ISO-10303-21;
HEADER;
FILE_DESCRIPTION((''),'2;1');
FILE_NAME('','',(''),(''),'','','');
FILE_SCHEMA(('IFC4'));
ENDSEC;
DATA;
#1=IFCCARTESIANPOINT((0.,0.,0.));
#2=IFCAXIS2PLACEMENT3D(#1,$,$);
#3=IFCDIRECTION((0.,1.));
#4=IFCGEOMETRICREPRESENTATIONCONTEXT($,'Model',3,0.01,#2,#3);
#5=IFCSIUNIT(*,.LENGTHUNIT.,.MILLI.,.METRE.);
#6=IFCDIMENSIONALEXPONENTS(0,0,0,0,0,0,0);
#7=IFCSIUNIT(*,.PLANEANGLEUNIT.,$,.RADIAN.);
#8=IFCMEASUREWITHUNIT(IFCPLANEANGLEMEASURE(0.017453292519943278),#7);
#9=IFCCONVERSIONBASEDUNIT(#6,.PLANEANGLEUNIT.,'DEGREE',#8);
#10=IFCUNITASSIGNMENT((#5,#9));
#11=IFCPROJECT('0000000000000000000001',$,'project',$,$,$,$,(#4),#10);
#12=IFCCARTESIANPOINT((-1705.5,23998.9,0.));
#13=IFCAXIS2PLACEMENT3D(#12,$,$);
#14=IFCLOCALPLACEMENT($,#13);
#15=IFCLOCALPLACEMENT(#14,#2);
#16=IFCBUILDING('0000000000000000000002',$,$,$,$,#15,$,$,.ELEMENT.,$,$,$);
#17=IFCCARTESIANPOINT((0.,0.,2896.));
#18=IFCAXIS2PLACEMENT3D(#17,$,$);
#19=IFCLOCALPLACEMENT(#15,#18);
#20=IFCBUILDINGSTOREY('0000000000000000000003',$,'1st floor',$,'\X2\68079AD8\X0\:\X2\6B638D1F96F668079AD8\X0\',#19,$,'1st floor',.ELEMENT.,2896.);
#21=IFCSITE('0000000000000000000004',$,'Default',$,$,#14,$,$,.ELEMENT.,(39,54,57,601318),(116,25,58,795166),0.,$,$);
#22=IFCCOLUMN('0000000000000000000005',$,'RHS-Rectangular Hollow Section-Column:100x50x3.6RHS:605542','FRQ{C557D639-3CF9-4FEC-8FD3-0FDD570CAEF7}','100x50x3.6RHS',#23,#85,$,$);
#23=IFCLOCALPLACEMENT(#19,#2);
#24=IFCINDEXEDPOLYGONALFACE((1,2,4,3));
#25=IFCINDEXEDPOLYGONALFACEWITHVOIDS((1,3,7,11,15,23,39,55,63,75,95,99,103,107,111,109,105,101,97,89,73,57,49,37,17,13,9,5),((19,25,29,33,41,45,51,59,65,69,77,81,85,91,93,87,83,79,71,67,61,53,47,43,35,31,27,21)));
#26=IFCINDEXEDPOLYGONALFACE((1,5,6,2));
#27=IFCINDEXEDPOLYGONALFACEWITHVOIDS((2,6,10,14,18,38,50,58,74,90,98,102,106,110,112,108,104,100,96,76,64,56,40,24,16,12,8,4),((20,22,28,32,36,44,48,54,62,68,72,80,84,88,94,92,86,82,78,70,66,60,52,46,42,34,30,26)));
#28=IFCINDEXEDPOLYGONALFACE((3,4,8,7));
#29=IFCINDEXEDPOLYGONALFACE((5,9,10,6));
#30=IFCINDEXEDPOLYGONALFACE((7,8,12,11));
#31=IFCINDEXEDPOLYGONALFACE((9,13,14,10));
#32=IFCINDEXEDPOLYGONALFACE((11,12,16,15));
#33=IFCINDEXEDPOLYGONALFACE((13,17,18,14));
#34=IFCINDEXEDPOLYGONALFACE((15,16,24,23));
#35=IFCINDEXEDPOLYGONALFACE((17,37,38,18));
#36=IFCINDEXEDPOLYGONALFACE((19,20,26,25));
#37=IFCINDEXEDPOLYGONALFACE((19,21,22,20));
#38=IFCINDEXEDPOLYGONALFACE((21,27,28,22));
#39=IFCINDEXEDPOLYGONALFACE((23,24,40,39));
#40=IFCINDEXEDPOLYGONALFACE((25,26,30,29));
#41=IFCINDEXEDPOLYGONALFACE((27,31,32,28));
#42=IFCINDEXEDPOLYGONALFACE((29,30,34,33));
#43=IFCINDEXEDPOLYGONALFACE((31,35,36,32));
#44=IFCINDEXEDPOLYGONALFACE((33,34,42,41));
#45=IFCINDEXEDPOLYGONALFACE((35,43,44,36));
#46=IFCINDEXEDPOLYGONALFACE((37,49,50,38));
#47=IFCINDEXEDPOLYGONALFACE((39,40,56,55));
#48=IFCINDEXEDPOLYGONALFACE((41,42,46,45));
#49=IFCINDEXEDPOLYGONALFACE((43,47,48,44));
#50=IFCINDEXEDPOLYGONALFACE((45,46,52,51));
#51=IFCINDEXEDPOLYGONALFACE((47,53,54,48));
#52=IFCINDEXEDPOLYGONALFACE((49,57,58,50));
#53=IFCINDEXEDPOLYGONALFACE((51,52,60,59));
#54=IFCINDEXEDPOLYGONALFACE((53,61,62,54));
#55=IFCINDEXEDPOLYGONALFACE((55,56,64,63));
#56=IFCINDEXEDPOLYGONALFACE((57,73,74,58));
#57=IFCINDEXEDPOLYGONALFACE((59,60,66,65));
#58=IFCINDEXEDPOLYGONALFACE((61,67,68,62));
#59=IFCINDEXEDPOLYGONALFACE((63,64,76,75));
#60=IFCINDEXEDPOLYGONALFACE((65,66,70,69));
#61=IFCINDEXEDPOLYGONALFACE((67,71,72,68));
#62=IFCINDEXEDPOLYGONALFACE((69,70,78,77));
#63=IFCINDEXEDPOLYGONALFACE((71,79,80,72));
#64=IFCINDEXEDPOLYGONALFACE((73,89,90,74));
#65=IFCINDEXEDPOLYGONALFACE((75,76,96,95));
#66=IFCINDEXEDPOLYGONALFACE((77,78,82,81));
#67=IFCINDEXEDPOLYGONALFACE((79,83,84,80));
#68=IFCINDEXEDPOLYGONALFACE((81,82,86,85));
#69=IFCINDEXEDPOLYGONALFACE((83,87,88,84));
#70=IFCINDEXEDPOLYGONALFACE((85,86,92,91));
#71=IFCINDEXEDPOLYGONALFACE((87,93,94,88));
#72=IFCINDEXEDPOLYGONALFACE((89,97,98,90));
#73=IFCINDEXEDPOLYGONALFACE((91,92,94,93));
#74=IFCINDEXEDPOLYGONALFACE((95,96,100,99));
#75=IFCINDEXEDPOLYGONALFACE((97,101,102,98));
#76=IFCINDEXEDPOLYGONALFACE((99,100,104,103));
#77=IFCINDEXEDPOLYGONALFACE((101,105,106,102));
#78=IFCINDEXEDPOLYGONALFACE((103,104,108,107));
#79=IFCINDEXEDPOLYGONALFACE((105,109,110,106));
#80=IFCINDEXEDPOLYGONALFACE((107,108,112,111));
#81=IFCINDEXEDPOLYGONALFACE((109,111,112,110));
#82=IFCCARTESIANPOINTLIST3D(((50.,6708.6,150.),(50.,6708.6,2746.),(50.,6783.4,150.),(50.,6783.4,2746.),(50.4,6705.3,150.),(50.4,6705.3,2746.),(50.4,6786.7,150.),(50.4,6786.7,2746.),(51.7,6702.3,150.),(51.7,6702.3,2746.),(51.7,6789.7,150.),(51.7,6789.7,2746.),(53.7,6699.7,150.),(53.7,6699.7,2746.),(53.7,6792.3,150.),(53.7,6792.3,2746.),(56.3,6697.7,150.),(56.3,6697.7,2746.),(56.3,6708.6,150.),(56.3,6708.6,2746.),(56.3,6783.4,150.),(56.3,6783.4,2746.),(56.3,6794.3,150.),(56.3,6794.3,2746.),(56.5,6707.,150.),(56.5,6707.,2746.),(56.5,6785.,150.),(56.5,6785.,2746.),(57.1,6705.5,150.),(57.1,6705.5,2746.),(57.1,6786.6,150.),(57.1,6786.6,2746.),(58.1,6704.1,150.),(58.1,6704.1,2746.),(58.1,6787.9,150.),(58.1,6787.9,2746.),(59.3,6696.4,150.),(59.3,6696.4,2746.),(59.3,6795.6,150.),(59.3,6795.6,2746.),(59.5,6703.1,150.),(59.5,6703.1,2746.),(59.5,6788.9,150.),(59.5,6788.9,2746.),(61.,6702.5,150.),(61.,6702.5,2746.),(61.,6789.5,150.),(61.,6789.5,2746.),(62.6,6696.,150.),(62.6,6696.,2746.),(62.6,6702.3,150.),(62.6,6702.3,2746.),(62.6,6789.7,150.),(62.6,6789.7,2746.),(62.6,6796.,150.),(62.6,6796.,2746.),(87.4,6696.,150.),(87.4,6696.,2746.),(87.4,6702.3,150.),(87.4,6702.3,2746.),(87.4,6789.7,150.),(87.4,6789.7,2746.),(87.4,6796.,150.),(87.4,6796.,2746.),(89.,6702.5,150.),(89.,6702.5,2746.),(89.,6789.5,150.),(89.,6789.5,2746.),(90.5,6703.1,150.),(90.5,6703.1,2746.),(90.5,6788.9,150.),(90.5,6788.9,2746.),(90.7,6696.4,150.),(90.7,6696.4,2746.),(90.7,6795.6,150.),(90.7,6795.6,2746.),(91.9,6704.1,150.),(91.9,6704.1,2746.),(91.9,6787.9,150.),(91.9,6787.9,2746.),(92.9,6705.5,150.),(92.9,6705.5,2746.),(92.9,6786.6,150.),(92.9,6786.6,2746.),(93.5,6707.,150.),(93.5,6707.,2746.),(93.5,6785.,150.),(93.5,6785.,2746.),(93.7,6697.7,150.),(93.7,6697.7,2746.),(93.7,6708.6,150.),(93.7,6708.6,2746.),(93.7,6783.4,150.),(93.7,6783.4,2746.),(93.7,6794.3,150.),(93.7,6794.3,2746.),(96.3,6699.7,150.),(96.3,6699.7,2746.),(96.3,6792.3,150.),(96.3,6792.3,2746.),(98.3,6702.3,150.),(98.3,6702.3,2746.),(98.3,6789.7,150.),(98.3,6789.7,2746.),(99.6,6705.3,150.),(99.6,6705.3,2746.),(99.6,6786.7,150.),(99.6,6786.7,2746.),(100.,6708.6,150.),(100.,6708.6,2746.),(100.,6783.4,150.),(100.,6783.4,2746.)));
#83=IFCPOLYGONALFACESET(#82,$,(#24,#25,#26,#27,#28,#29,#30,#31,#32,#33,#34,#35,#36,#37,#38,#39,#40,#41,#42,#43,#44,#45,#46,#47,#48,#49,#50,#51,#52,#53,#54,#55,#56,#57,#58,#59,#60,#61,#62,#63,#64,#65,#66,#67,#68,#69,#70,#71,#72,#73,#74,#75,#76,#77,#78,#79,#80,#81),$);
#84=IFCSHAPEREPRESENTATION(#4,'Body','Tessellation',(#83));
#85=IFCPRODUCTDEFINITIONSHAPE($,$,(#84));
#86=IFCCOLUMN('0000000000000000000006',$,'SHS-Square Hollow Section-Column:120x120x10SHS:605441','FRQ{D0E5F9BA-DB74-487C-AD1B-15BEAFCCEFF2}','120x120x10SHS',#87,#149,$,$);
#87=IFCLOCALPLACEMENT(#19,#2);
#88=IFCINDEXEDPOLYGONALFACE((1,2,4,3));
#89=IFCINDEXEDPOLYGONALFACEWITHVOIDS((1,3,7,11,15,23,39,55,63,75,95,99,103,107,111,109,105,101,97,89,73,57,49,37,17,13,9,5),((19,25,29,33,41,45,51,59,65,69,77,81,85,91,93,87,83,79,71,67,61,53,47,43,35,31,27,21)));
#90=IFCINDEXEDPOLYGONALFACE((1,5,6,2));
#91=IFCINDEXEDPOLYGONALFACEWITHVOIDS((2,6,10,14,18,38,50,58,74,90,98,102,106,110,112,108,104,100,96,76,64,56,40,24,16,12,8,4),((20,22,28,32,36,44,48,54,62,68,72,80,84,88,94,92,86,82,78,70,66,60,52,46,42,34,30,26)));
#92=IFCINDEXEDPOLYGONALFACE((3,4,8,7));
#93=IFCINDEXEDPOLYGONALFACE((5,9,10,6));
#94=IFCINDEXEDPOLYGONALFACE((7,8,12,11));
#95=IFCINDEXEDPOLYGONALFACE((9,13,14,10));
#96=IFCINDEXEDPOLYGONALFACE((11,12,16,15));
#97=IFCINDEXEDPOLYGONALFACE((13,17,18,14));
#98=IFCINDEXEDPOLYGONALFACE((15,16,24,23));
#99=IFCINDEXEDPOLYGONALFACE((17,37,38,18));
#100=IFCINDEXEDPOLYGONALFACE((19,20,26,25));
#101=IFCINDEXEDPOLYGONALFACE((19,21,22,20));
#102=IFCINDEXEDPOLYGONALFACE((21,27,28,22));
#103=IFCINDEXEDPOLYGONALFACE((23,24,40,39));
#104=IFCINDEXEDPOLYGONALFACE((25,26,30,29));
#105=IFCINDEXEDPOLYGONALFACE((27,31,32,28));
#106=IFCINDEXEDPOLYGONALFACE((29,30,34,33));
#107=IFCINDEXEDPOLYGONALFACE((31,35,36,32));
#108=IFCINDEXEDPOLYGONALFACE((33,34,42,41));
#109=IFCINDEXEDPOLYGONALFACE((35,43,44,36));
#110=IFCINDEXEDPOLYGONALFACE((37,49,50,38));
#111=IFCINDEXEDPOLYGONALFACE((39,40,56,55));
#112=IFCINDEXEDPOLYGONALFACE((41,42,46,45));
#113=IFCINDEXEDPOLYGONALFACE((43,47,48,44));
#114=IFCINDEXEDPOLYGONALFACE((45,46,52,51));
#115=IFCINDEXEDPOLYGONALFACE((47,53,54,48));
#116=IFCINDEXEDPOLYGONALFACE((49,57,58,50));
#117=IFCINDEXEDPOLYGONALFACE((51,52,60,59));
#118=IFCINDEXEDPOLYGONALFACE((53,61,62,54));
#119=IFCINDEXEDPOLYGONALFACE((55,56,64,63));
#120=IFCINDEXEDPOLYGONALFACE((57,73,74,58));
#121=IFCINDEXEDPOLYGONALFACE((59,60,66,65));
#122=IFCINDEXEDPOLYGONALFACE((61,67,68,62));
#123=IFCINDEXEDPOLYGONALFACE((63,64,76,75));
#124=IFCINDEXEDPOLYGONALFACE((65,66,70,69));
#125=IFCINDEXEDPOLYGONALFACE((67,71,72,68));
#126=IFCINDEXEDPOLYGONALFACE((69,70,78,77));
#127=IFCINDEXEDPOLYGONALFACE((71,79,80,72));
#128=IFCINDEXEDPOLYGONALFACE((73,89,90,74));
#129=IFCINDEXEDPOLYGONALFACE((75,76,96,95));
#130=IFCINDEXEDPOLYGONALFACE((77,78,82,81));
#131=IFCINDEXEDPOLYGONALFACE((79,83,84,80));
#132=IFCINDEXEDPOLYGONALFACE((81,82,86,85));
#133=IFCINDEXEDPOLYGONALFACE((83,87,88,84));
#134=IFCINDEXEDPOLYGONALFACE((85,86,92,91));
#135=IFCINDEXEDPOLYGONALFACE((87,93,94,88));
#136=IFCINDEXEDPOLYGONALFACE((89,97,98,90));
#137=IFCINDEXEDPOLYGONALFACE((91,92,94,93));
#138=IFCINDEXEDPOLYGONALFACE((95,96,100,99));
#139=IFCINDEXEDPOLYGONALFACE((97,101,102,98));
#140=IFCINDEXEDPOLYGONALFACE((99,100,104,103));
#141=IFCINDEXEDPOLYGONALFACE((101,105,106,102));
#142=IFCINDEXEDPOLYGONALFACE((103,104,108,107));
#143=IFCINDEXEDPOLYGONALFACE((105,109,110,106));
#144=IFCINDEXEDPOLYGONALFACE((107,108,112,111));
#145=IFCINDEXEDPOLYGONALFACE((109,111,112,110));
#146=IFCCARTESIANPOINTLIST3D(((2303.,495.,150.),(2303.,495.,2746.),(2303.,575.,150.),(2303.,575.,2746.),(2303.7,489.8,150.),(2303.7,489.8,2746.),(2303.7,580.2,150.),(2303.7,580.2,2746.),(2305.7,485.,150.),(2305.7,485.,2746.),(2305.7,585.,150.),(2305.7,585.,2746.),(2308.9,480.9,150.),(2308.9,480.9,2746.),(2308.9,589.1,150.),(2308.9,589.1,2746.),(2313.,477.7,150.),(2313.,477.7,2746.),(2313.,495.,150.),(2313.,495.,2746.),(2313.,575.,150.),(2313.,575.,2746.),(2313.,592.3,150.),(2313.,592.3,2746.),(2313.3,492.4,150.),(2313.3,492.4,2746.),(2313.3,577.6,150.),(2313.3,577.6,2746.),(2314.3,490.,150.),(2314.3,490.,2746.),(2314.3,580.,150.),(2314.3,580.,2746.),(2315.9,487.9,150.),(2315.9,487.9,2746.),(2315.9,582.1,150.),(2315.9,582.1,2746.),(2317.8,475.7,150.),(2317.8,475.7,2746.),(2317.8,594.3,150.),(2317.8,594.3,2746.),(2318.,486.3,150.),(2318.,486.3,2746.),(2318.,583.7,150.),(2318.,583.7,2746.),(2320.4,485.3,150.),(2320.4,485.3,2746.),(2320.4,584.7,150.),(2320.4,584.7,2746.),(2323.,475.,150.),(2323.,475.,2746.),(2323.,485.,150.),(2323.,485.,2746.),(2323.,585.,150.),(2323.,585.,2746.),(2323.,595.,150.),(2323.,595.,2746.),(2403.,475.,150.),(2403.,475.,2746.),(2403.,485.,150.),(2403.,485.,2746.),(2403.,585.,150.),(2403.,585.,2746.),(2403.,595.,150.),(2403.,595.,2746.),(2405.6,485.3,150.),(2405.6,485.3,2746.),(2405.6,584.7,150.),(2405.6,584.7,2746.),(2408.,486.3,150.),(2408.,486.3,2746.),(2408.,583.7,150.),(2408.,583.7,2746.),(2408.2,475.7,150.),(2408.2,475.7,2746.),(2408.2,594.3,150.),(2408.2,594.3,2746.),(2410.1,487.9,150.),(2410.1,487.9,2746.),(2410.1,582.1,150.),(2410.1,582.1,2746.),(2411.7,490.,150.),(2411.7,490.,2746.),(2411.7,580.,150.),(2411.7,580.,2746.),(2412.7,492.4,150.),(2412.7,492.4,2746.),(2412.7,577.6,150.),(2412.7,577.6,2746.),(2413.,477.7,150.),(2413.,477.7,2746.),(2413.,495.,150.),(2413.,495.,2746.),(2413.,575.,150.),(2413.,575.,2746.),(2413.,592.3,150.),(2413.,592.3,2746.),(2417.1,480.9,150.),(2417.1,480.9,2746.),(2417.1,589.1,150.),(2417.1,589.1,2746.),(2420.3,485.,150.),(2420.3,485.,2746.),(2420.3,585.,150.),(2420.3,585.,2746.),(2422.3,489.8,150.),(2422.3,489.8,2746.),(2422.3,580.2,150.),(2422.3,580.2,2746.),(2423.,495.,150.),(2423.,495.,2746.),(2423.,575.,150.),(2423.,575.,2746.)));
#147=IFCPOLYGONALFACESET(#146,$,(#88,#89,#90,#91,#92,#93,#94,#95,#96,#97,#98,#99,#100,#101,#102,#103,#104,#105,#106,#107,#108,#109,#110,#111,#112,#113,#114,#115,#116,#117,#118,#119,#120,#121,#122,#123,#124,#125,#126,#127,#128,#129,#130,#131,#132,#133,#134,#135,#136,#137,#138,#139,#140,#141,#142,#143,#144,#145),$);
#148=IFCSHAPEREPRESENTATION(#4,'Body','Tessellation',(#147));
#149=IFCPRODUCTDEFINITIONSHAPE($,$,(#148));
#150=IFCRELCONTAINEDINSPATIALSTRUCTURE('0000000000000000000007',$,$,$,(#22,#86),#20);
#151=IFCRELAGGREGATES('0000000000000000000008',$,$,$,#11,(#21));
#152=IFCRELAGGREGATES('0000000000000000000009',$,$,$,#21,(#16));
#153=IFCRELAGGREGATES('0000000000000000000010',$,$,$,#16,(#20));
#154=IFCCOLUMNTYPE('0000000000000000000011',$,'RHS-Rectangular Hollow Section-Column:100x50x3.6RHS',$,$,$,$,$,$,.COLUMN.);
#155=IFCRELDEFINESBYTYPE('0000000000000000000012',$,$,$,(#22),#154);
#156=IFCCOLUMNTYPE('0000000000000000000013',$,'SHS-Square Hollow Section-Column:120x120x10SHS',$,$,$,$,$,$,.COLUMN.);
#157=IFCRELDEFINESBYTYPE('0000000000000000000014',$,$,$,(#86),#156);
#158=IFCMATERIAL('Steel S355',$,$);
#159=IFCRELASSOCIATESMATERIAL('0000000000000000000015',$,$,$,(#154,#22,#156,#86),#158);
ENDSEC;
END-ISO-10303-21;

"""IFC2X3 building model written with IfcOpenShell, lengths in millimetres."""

from ifc_helpers import new_model, entity, si_unit, converted_unit, direction, frame, origin, origin_2d, place, context, project, spatial, hollow_rectangle, extrude, clip, halfspace, material, type_object, element, save


model = new_model("IFC2X3")

# Units and contexts
model_context = context("Model", 3, precision=0.01, world=origin(), true_north=direction((0.0, 1.0)))
ifc_project = project(units=[si_unit("LENGTHUNIT", "METRE", prefix="MILLI"), converted_unit("PLANEANGLEUNIT", "DEGREE", entity("IfcPlaneAngleMeasure", 0.017453292519943278), si_unit("PLANEANGLEUNIT", "RADIAN"), dimensions=[0, 0, 0, 0, 0, 0, 0])], contexts=[model_context])

# Site, building, storey
site_placement = place(None, frame((-1705.5, 23998.9, 0.0)))
site = spatial("IfcSite", under=ifc_project, at=site_placement, Name="Default", CompositionType="ELEMENT", RefLatitude=(39, 54, 57, 601318), RefLongitude=(116, 25, 58, 795166), RefElevation=0.0)
building_placement = place(site_placement, origin())
building = spatial("IfcBuilding", under=site, at=building_placement, CompositionType="ELEMENT")
storey_placement = place(building_placement, frame((0.0, 0.0, 2896.0)))
storey = spatial("IfcBuildingStorey", under=building, at=storey_placement, Name="1st floor", ObjectType="标高:正负零标高", LongName="1st floor", CompositionType="ELEMENT", Elevation=2896.0)

# Shared definitions
ifc_material_1 = material(Name="Steel S355")

# Columns
column_type_1 = type_object("IfcColumnType", Name="RHS-Rectangular Hollow Section-Column:100x50x3.6RHS", PredefinedType="COLUMN", material=ifc_material_1)
column_1_placement = place(storey_placement, frame((75.0, 6746.0, 2746.0), z_axis=(0.0, 0.0, 1.0), x_axis=(-1.0, 0.0, 0.0)))
element("IfcColumn", 1, at=column_1_placement, inside=storey, type_object=column_type_1, material=ifc_material_1, Name="RHS-Rectangular Hollow Section-Column:100x50x3.6RHS:605542", Description="FRQ{C557D639-3CF9-4FEC-8FD3-0FDD570CAEF7}", ObjectType="100x50x3.6RHS", context=model_context, shape_type="Clipping", body=[
    clip(extrude(hollow_rectangle(XDim=50.0, YDim=100.0, WallThickness=6.3, InnerFilletRadius=6.3, OuterFilletRadius=12.6, at=origin_2d()), origin(), (0.0, 0.0, -1.0), 2651.9), halfspace(frame((75.0, 6746.0, -2596.0), z_axis=(0.0, 0.0, 1.0), x_axis=(-1.0, 0.0, 0.0)), True)),
])
column_type_2 = type_object("IfcColumnType", Name="SHS-Square Hollow Section-Column:120x120x10SHS", PredefinedType="COLUMN", material=ifc_material_1)
column_2_placement = place(storey_placement, frame((2363.0, 535.0, 2746.0), z_axis=(0.0, 0.0, 1.0), x_axis=(0.0, -1.0, 0.0)))
element("IfcColumn", 2, at=column_2_placement, inside=storey, type_object=column_type_2, material=ifc_material_1, Name="SHS-Square Hollow Section-Column:120x120x10SHS:605441", Description="FRQ{D0E5F9BA-DB74-487C-AD1B-15BEAFCCEFF2}", ObjectType="120x120x10SHS", context=model_context, shape_type="Clipping", body=[
    clip(extrude(hollow_rectangle(XDim=120.0, YDim=120.0, WallThickness=10.0, InnerFilletRadius=10.0, OuterFilletRadius=20.0, at=origin_2d()), origin(), (0.0, 0.0, -1.0), 2680.9), halfspace(frame((535.0, -2363.0, -2596.0), z_axis=(0.0, 0.0, 1.0), x_axis=(0.0, 1.0, 0.0)), True)),
])

save(model, "model.ifc")
